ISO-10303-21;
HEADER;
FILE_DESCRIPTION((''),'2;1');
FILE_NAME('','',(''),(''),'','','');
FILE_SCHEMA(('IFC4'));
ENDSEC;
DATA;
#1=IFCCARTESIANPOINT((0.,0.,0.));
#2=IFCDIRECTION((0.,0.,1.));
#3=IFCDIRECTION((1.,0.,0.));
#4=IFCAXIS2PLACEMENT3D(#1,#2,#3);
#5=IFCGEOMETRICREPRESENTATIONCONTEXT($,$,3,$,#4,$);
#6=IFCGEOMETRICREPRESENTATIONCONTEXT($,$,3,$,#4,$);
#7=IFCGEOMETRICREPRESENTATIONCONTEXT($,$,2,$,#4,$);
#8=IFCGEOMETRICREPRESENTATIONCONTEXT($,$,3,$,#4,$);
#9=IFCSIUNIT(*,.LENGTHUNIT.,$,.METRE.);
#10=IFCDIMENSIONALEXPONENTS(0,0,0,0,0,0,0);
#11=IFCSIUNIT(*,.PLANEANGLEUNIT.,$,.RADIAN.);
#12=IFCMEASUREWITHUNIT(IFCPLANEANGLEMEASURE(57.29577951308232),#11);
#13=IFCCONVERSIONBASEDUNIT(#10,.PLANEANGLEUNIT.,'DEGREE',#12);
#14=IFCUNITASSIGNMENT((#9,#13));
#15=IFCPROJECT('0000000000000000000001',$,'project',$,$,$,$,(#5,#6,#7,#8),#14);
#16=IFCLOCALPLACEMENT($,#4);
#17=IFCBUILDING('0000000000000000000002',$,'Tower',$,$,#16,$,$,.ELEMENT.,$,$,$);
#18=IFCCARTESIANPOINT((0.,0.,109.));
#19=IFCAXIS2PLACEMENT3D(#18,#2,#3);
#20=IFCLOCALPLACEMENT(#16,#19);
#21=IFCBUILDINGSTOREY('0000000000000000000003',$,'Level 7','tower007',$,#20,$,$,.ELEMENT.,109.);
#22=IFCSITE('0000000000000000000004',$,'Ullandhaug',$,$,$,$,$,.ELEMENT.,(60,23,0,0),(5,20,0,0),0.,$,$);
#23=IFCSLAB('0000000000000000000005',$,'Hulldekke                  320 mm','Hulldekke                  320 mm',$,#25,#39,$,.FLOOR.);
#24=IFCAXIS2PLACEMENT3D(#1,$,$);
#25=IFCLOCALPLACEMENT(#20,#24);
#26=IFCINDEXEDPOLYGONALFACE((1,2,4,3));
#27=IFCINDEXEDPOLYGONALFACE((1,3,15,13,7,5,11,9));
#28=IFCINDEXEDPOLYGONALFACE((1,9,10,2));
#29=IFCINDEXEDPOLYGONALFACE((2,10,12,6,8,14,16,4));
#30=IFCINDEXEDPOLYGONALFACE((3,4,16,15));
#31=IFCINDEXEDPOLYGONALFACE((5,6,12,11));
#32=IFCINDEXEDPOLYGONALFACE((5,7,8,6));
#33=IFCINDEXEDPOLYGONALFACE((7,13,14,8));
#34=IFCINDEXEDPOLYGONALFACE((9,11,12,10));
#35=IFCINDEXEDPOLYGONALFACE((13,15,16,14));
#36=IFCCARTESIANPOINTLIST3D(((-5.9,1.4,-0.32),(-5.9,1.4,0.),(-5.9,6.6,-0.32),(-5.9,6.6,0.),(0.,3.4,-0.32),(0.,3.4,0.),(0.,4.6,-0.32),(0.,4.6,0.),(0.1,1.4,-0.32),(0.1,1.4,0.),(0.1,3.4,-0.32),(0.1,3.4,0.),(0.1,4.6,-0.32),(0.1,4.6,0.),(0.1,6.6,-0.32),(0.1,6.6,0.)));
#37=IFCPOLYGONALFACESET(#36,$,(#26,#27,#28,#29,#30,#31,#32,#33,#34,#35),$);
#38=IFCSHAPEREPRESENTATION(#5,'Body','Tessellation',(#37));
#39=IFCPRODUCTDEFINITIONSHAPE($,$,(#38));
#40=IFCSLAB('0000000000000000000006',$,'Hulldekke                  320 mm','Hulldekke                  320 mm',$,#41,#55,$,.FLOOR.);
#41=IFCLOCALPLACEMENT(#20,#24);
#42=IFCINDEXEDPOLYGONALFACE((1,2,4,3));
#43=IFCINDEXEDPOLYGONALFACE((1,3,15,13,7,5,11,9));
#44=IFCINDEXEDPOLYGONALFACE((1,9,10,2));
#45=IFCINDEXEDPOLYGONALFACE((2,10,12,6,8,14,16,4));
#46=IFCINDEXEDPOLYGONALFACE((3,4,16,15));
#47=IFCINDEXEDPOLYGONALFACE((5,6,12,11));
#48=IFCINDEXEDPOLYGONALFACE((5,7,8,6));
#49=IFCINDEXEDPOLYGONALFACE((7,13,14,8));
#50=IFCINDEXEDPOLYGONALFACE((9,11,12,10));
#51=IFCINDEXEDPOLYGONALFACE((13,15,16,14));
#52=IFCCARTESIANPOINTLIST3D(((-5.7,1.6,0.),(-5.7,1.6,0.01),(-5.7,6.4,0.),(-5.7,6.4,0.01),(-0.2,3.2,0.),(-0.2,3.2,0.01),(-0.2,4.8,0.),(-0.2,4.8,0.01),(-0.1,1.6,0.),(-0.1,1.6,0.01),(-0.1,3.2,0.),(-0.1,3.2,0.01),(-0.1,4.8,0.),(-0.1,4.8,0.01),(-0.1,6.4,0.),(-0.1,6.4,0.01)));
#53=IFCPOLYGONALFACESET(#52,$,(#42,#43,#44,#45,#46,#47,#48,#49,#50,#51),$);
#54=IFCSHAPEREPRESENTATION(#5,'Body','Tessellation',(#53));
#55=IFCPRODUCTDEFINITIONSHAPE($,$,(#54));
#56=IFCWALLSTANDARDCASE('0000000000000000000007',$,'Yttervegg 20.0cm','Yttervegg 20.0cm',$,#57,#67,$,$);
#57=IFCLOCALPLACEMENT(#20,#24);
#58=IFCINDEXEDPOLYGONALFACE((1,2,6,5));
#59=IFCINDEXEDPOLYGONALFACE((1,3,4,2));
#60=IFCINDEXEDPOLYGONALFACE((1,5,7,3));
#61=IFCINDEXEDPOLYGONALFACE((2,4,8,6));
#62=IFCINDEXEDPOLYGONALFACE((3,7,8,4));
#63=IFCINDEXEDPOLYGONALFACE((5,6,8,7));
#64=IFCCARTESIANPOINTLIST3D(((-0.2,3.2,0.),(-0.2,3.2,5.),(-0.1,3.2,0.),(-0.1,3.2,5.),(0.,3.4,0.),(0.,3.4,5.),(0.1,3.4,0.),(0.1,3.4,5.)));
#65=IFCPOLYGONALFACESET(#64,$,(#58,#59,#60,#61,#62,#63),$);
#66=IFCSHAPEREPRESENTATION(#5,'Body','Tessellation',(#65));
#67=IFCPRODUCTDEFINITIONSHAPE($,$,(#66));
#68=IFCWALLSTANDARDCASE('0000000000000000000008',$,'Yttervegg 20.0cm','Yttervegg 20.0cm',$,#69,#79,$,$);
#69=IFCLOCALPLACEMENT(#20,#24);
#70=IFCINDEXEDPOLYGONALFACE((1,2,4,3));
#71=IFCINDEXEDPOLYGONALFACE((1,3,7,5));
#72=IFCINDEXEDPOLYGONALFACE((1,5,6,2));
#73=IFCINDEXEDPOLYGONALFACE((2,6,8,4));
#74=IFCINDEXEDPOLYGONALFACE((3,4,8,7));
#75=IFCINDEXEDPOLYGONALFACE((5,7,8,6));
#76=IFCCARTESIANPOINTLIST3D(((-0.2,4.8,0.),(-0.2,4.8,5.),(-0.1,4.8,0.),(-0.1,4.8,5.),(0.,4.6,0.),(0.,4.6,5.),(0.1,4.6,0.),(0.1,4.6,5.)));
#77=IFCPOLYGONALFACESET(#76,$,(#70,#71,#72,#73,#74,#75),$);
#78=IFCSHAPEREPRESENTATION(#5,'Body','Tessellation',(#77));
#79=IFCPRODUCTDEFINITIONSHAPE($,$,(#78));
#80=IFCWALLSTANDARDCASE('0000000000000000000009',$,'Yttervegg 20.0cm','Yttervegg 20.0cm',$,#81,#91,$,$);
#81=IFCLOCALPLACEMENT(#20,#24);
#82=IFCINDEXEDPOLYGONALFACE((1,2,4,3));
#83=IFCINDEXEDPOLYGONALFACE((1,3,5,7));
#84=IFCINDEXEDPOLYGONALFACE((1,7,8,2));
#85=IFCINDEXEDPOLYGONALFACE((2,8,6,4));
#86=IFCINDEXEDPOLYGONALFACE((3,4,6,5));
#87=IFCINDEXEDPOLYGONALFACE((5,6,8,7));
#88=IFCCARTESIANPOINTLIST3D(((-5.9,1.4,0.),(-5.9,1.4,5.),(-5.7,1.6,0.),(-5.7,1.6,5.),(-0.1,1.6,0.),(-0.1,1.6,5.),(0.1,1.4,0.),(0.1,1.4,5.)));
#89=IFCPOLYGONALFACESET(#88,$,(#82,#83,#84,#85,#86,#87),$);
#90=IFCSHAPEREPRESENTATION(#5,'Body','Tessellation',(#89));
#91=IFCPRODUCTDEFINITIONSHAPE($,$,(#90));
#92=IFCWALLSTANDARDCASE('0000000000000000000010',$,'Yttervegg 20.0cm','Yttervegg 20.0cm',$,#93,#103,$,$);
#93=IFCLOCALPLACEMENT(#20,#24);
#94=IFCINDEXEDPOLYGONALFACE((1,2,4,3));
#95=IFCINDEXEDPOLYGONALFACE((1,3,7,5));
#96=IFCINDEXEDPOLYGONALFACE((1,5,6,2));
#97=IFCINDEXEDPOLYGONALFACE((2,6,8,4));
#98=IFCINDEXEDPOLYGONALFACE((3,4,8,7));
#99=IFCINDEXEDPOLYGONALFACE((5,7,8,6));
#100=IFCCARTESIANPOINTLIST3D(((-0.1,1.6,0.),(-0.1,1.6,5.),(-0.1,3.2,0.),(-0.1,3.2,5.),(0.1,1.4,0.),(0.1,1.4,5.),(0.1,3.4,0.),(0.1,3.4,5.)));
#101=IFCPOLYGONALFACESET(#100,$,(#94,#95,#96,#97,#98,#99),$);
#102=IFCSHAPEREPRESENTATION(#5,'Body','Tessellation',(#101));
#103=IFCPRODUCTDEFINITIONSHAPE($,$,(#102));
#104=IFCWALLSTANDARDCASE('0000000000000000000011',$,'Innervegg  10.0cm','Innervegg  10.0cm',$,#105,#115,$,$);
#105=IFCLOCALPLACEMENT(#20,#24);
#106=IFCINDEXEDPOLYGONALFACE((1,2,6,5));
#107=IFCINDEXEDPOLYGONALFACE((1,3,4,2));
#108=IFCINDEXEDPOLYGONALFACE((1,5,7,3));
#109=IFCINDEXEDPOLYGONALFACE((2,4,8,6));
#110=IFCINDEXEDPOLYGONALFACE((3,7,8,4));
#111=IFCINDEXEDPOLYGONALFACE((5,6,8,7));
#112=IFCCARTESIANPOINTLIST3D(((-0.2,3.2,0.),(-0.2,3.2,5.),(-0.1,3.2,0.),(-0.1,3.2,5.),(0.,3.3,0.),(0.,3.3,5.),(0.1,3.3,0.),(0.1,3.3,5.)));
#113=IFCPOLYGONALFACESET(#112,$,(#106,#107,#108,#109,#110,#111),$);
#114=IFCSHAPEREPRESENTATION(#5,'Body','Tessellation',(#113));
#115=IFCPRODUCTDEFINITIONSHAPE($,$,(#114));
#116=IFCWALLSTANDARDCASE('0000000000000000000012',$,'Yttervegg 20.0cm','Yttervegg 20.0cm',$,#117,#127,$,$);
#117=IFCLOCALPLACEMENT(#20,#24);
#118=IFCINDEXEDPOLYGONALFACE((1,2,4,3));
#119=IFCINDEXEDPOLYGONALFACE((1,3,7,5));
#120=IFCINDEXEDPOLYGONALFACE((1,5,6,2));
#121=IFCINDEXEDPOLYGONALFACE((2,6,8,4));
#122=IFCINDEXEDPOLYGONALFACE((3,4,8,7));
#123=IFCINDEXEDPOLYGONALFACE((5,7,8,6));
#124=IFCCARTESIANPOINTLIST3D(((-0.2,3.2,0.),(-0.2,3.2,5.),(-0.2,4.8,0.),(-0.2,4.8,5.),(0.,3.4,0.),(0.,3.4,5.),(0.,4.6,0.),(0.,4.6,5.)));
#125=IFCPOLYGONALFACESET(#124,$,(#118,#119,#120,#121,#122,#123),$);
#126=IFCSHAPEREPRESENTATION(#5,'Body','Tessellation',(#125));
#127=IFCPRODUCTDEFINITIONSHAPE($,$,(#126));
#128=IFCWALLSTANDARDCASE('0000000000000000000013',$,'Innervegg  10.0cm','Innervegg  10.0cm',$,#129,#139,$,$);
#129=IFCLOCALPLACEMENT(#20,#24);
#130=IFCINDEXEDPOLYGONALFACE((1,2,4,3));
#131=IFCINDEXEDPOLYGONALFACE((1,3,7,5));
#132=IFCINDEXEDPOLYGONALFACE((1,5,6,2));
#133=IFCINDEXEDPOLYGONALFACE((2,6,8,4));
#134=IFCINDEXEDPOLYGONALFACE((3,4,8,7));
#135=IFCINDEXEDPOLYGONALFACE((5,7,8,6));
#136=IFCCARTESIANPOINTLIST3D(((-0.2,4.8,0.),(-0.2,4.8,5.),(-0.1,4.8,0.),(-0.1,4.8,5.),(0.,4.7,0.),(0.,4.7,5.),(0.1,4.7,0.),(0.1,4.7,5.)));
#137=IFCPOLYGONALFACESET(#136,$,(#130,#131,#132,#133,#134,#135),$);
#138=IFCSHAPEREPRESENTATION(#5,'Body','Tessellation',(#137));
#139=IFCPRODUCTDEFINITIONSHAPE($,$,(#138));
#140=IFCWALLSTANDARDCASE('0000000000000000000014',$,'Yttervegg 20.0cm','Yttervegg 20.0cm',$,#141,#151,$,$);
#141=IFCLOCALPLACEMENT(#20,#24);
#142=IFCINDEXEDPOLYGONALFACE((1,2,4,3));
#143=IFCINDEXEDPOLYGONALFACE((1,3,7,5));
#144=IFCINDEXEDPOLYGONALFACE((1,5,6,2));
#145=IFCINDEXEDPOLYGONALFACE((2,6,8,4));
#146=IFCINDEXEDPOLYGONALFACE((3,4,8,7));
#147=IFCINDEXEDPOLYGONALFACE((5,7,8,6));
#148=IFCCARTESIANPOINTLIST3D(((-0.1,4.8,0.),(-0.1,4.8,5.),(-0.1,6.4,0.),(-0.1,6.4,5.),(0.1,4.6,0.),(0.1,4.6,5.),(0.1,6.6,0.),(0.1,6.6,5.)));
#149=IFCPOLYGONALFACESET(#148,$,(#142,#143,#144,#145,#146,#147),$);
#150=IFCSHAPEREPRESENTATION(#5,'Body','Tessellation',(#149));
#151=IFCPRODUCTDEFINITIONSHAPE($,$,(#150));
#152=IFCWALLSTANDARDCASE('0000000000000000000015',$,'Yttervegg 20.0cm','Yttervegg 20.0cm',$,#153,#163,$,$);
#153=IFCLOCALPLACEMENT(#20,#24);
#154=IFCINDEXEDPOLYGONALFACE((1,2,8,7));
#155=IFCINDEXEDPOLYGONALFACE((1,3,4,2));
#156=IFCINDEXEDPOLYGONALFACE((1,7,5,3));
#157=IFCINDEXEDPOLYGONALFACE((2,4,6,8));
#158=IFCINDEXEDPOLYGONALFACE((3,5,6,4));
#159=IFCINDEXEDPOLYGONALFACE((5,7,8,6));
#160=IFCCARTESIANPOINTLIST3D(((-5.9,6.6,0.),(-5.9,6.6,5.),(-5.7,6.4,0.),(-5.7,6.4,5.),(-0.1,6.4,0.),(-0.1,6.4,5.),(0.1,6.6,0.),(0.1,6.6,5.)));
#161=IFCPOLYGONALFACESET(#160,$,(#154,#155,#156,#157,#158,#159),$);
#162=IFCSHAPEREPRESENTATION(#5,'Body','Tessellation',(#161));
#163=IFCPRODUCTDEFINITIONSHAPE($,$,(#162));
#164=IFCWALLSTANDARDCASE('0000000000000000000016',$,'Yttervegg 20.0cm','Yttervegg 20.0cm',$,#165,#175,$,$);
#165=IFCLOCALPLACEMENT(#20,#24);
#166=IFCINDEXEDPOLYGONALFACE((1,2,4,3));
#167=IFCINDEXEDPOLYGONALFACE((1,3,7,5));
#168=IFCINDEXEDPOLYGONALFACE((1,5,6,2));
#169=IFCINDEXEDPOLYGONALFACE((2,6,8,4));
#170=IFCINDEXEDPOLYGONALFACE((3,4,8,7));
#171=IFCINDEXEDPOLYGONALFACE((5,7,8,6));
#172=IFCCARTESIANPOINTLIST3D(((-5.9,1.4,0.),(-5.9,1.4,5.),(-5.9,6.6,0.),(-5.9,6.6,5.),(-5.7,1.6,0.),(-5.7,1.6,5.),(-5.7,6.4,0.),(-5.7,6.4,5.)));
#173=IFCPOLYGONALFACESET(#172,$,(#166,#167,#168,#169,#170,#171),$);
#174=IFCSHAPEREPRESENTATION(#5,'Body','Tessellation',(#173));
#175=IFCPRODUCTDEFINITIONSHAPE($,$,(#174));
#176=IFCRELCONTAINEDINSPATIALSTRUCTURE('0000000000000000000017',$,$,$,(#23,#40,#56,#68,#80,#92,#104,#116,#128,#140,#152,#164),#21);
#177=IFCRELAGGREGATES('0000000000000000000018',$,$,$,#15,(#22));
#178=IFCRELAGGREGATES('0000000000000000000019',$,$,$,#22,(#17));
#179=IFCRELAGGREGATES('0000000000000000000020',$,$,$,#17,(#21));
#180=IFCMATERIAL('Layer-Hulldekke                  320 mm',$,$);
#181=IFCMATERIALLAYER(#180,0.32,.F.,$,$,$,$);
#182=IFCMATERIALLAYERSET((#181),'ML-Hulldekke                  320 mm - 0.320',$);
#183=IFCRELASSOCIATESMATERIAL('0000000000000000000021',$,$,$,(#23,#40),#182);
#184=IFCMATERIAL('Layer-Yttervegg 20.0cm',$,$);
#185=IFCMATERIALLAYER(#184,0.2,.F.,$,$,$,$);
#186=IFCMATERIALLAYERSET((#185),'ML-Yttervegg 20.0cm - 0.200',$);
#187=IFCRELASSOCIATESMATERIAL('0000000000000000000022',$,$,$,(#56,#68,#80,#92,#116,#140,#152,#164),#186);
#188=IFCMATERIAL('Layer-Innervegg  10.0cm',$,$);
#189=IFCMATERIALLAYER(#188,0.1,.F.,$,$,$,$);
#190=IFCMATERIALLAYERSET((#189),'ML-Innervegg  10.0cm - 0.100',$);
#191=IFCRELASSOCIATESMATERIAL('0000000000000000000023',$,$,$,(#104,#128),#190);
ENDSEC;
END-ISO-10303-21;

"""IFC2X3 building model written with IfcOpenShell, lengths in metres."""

from ifc_helpers import new_model, entity, si_unit, converted_unit, frame, origin_with_axes, place, context, project, spatial, polyline, outline, extrude, material, layer, layer_set, layer_usage, element, save


model = new_model("IFC2X3")

# Units and contexts
context_of_model_1 = context(None, 3, world=origin_with_axes())
context_of_model_2 = context(None, 3, world=origin_with_axes())
context_of_model_3 = context(None, 2, world=origin_with_axes())
context_of_model_4 = context(None, 3, world=origin_with_axes())
ifc_project = project(units=[si_unit("LENGTHUNIT", "METRE"), converted_unit("PLANEANGLEUNIT", "DEGREE", entity("IfcPlaneAngleMeasure", 57.29577951308232), si_unit("PLANEANGLEUNIT", "RADIAN"), dimensions=[0, 0, 0, 0, 0, 0, 0])], contexts=[context_of_model_1, context_of_model_2, context_of_model_3, context_of_model_4])

# Site, building, storey
site = spatial("IfcSite", under=ifc_project, Name="Ullandhaug", CompositionType="ELEMENT", RefLatitude=(60, 23, 0, 0), RefLongitude=(5, 20, 0, 0), RefElevation=0.0)
building_placement = place(None, origin_with_axes())
building = spatial("IfcBuilding", under=site, at=building_placement, Name="Tower", CompositionType="ELEMENT")
storey_placement = place(building_placement, frame((0.0, 0.0, 109.0), z_axis=(0.0, 0.0, 1.0), x_axis=(1.0, 0.0, 0.0)))
storey = spatial("IfcBuildingStorey", under=building, at=storey_placement, Name="Level 7", Description="tower007", CompositionType="ELEMENT", Elevation=109.0)

# Slabs
ifc_material_1 = material(Name="Layer-Hulldekke                  320 mm")
ifc_layer_1 = layer(ifc_material_1, 0.32, ventilated=False)
ifc_layer_set_1 = layer_set([ifc_layer_1], Name="ML-Hulldekke                  320 mm - 0.320")
ifc_layer_usage_1 = layer_usage(ifc_layer_set_1, "AXIS2", "POSITIVE", 0.0)
slab_1_placement = place(storey_placement, frame((-5.9, 1.4, 0.0), z_axis=(0.0, 0.0, 1.0), x_axis=(1.0, 0.0, 0.0)))
element("IfcSlab", 1, at=slab_1_placement, inside=storey, material=ifc_layer_usage_1, Name="Hulldekke                  320 mm", Description="Hulldekke                  320 mm", PredefinedType="FLOOR", context=context_of_model_1, shape_type="SweptSolid", body=[
    extrude(outline(polyline([(0.0, 0.0), (6.0, 0.0), (6.0, 2.0), (5.9, 2.0), (5.9, 3.2), (6.0, 3.2), (6.0, 5.2), (0.0, 5.2), (0.0, 0.0)])), origin_with_axes(), (0.0, 0.0, -1.0), 0.32),
])
slab_2_placement = place(storey_placement, frame((-5.7, 1.6, 0.0), z_axis=(0.0, 0.0, 1.0), x_axis=(1.0, 0.0, 0.0)))
element("IfcSlab", 2, at=slab_2_placement, inside=storey, material=ifc_layer_usage_1, Name="Hulldekke                  320 mm", Description="Hulldekke                  320 mm", PredefinedType="FLOOR", context=context_of_model_1, shape_type="SweptSolid", body=[
    extrude(outline(polyline([(0.0, 0.0), (5.6, 0.0), (5.6, 1.6), (5.5, 1.6), (5.5, 3.2), (5.6, 3.2), (5.6, 4.8), (0.0, 4.8), (0.0, 0.0)])), origin_with_axes(), (0.0, 0.0, 1.0), 0.01),
])

# Walls
ifc_material_2 = material(Name="Layer-Yttervegg 20.0cm")
ifc_layer_2 = layer(ifc_material_2, 0.2, ventilated=False)
ifc_layer_set_2 = layer_set([ifc_layer_2], Name="ML-Yttervegg 20.0cm - 0.200")
ifc_layer_usage_2 = layer_usage(ifc_layer_set_2, "AXIS2", "POSITIVE", 0.0)
wall_1_placement = place(storey_placement, frame((0.1, 3.4, 0.0), z_axis=(0.0, 0.0, 1.0), x_axis=(-1.0, 0.0, 0.0)))
element("IfcWallStandardCase", 3, at=wall_1_placement, inside=storey, material=ifc_layer_usage_2, Name="Yttervegg 20.0cm", Description="Yttervegg 20.0cm", context=context_of_model_1, shape_type="SweptSolid", body=[
    extrude(outline(polyline([(0.0, 0.0), (0.1, 0.0), (0.3, 0.2), (0.2, 0.2), (0.0, 0.0)])), frame((0.0, 0.0, 0.0), z_axis=(0.0, 0.0, 1.0), x_axis=(1.0, 0.0, 0.0)), (0.0, 0.0, 1.0), 5.0),
])
wall_2_placement = place(storey_placement, frame((0.0, 4.6, 0.0), z_axis=(0.0, 0.0, 1.0), x_axis=(1.0, 0.0, 0.0)))
element("IfcWallStandardCase", 4, at=wall_2_placement, inside=storey, material=ifc_layer_usage_2, Name="Yttervegg 20.0cm", Description="Yttervegg 20.0cm", context=context_of_model_1, shape_type="SweptSolid", body=[
    extrude(outline(polyline([(0.0, 0.0), (0.1, 0.0), (-0.1, 0.2), (-0.2, 0.2), (0.0, 0.0)])), origin_with_axes(), (0.0, 0.0, 1.0), 5.0),
])
wall_3_placement = place(storey_placement, frame((-5.9, 1.4, 0.0), z_axis=(0.0, 0.0, 1.0), x_axis=(1.0, 0.0, 0.0)))
element("IfcWallStandardCase", 5, at=wall_3_placement, inside=storey, material=ifc_layer_usage_2, Name="Yttervegg 20.0cm", Description="Yttervegg 20.0cm", context=context_of_model_1, shape_type="SweptSolid", body=[
    extrude(outline(polyline([(0.0, 0.0), (6.0, 0.0), (5.8, 0.2), (0.2, 0.2), (0.0, 0.0)])), origin_with_axes(), (0.0, 0.0, 1.0), 5.0),
])
wall_4_placement = place(storey_placement, frame((0.1, 1.4, 0.0), z_axis=(0.0, 0.0, 1.0), x_axis=(0.0, 1.0, 0.0)))
element("IfcWallStandardCase", 6, at=wall_4_placement, inside=storey, material=ifc_layer_usage_2, Name="Yttervegg 20.0cm", Description="Yttervegg 20.0cm", context=context_of_model_1, shape_type="SweptSolid", body=[
    extrude(outline(polyline([(0.0, 0.0), (2.0, 0.0), (1.8, 0.2), (0.2, 0.2), (0.0, 0.0)])), frame((0.0, 0.0, 0.0), z_axis=(0.0, 0.0, 1.0), x_axis=(1.0, 0.0, 0.0)), (0.0, 0.0, 1.0), 5.0),
])
ifc_material_3 = material(Name="Layer-Innervegg  10.0cm")
ifc_layer_3 = layer(ifc_material_3, 0.1, ventilated=False)
ifc_layer_set_3 = layer_set([ifc_layer_3], Name="ML-Innervegg  10.0cm - 0.100")
ifc_layer_usage_3 = layer_usage(ifc_layer_set_3, "AXIS2", "POSITIVE", 0.0)
wall_5_placement = place(storey_placement, frame((0.1, 3.3, 0.0), z_axis=(0.0, 0.0, 1.0), x_axis=(-1.0, 0.0, 0.0)))
element("IfcWallStandardCase", 7, at=wall_5_placement, inside=storey, material=ifc_layer_usage_3, Name="Innervegg  10.0cm", Description="Innervegg  10.0cm", context=context_of_model_1, shape_type="SweptSolid", body=[
    extrude(outline(polyline([(0.0, 0.0), (0.1, 0.0), (0.3, 0.1), (0.2, 0.1), (0.0, 0.0)])), frame((0.0, 0.0, 0.0), z_axis=(0.0, 0.0, 1.0), x_axis=(1.0, 0.0, 0.0)), (0.0, 0.0, 1.0), 5.0),
])
wall_6_placement = place(storey_placement, frame((0.0, 3.4, 0.0), z_axis=(0.0, 0.0, 1.0), x_axis=(0.0, 1.0, 0.0)))
element("IfcWallStandardCase", 8, at=wall_6_placement, inside=storey, material=ifc_layer_usage_2, Name="Yttervegg 20.0cm", Description="Yttervegg 20.0cm", context=context_of_model_1, shape_type="SweptSolid", body=[
    extrude(outline(polyline([(0.0, 0.0), (1.2, 0.0), (1.4, 0.2), (-0.2, 0.2), (0.0, 0.0)])), frame((0.0, 0.0, 0.0), z_axis=(0.0, 0.0, 1.0), x_axis=(1.0, 0.0, 0.0)), (0.0, 0.0, 1.0), 5.0),
])
wall_7_placement = place(storey_placement, frame((0.0, 4.7, 0.0), z_axis=(0.0, 0.0, 1.0), x_axis=(1.0, 0.0, 0.0)))
element("IfcWallStandardCase", 9, at=wall_7_placement, inside=storey, material=ifc_layer_usage_3, Name="Innervegg  10.0cm", Description="Innervegg  10.0cm", context=context_of_model_1, shape_type="SweptSolid", body=[
    extrude(outline(polyline([(0.0, 0.0), (0.1, 0.0), (-0.1, 0.1), (-0.2, 0.1), (0.0, 0.0)])), origin_with_axes(), (0.0, 0.0, 1.0), 5.0),
])
wall_8_placement = place(storey_placement, frame((0.1, 4.6, 0.0), z_axis=(0.0, 0.0, 1.0), x_axis=(0.0, 1.0, 0.0)))
element("IfcWallStandardCase", 10, at=wall_8_placement, inside=storey, material=ifc_layer_usage_2, Name="Yttervegg 20.0cm", Description="Yttervegg 20.0cm", context=context_of_model_1, shape_type="SweptSolid", body=[
    extrude(outline(polyline([(0.0, 0.0), (2.0, 0.0), (1.8, 0.2), (0.2, 0.2), (0.0, 0.0)])), frame((0.0, 0.0, 0.0), z_axis=(0.0, 0.0, 1.0), x_axis=(1.0, 0.0, 0.0)), (0.0, 0.0, 1.0), 5.0),
])
wall_9_placement = place(storey_placement, frame((0.1, 6.6, 0.0), z_axis=(0.0, 0.0, 1.0), x_axis=(-1.0, 0.0, 0.0)))
element("IfcWallStandardCase", 11, at=wall_9_placement, inside=storey, material=ifc_layer_usage_2, Name="Yttervegg 20.0cm", Description="Yttervegg 20.0cm", context=context_of_model_1, shape_type="SweptSolid", body=[
    extrude(outline(polyline([(0.0, 0.0), (6.0, 0.0), (5.8, 0.2), (0.2, 0.2), (0.0, 0.0)])), frame((0.0, 0.0, 0.0), z_axis=(0.0, 0.0, 1.0), x_axis=(1.0, 0.0, 0.0)), (0.0, 0.0, 1.0), 5.0),
])
wall_10_placement = place(storey_placement, frame((-5.9, 6.6, 0.0), z_axis=(0.0, 0.0, 1.0), x_axis=(0.0, -1.0, 0.0)))
element("IfcWallStandardCase", 12, at=wall_10_placement, inside=storey, material=ifc_layer_usage_2, Name="Yttervegg 20.0cm", Description="Yttervegg 20.0cm", context=context_of_model_1, shape_type="SweptSolid", body=[
    extrude(outline(polyline([(0.0, 0.0), (5.2, 0.0), (5.0, 0.2), (0.2, 0.2), (0.0, 0.0)])), frame((0.0, 0.0, 0.0), z_axis=(0.0, 0.0, 1.0), x_axis=(1.0, 0.0, 0.0)), (0.0, 0.0, 1.0), 5.0),
])

save(model, "model.ifc")
